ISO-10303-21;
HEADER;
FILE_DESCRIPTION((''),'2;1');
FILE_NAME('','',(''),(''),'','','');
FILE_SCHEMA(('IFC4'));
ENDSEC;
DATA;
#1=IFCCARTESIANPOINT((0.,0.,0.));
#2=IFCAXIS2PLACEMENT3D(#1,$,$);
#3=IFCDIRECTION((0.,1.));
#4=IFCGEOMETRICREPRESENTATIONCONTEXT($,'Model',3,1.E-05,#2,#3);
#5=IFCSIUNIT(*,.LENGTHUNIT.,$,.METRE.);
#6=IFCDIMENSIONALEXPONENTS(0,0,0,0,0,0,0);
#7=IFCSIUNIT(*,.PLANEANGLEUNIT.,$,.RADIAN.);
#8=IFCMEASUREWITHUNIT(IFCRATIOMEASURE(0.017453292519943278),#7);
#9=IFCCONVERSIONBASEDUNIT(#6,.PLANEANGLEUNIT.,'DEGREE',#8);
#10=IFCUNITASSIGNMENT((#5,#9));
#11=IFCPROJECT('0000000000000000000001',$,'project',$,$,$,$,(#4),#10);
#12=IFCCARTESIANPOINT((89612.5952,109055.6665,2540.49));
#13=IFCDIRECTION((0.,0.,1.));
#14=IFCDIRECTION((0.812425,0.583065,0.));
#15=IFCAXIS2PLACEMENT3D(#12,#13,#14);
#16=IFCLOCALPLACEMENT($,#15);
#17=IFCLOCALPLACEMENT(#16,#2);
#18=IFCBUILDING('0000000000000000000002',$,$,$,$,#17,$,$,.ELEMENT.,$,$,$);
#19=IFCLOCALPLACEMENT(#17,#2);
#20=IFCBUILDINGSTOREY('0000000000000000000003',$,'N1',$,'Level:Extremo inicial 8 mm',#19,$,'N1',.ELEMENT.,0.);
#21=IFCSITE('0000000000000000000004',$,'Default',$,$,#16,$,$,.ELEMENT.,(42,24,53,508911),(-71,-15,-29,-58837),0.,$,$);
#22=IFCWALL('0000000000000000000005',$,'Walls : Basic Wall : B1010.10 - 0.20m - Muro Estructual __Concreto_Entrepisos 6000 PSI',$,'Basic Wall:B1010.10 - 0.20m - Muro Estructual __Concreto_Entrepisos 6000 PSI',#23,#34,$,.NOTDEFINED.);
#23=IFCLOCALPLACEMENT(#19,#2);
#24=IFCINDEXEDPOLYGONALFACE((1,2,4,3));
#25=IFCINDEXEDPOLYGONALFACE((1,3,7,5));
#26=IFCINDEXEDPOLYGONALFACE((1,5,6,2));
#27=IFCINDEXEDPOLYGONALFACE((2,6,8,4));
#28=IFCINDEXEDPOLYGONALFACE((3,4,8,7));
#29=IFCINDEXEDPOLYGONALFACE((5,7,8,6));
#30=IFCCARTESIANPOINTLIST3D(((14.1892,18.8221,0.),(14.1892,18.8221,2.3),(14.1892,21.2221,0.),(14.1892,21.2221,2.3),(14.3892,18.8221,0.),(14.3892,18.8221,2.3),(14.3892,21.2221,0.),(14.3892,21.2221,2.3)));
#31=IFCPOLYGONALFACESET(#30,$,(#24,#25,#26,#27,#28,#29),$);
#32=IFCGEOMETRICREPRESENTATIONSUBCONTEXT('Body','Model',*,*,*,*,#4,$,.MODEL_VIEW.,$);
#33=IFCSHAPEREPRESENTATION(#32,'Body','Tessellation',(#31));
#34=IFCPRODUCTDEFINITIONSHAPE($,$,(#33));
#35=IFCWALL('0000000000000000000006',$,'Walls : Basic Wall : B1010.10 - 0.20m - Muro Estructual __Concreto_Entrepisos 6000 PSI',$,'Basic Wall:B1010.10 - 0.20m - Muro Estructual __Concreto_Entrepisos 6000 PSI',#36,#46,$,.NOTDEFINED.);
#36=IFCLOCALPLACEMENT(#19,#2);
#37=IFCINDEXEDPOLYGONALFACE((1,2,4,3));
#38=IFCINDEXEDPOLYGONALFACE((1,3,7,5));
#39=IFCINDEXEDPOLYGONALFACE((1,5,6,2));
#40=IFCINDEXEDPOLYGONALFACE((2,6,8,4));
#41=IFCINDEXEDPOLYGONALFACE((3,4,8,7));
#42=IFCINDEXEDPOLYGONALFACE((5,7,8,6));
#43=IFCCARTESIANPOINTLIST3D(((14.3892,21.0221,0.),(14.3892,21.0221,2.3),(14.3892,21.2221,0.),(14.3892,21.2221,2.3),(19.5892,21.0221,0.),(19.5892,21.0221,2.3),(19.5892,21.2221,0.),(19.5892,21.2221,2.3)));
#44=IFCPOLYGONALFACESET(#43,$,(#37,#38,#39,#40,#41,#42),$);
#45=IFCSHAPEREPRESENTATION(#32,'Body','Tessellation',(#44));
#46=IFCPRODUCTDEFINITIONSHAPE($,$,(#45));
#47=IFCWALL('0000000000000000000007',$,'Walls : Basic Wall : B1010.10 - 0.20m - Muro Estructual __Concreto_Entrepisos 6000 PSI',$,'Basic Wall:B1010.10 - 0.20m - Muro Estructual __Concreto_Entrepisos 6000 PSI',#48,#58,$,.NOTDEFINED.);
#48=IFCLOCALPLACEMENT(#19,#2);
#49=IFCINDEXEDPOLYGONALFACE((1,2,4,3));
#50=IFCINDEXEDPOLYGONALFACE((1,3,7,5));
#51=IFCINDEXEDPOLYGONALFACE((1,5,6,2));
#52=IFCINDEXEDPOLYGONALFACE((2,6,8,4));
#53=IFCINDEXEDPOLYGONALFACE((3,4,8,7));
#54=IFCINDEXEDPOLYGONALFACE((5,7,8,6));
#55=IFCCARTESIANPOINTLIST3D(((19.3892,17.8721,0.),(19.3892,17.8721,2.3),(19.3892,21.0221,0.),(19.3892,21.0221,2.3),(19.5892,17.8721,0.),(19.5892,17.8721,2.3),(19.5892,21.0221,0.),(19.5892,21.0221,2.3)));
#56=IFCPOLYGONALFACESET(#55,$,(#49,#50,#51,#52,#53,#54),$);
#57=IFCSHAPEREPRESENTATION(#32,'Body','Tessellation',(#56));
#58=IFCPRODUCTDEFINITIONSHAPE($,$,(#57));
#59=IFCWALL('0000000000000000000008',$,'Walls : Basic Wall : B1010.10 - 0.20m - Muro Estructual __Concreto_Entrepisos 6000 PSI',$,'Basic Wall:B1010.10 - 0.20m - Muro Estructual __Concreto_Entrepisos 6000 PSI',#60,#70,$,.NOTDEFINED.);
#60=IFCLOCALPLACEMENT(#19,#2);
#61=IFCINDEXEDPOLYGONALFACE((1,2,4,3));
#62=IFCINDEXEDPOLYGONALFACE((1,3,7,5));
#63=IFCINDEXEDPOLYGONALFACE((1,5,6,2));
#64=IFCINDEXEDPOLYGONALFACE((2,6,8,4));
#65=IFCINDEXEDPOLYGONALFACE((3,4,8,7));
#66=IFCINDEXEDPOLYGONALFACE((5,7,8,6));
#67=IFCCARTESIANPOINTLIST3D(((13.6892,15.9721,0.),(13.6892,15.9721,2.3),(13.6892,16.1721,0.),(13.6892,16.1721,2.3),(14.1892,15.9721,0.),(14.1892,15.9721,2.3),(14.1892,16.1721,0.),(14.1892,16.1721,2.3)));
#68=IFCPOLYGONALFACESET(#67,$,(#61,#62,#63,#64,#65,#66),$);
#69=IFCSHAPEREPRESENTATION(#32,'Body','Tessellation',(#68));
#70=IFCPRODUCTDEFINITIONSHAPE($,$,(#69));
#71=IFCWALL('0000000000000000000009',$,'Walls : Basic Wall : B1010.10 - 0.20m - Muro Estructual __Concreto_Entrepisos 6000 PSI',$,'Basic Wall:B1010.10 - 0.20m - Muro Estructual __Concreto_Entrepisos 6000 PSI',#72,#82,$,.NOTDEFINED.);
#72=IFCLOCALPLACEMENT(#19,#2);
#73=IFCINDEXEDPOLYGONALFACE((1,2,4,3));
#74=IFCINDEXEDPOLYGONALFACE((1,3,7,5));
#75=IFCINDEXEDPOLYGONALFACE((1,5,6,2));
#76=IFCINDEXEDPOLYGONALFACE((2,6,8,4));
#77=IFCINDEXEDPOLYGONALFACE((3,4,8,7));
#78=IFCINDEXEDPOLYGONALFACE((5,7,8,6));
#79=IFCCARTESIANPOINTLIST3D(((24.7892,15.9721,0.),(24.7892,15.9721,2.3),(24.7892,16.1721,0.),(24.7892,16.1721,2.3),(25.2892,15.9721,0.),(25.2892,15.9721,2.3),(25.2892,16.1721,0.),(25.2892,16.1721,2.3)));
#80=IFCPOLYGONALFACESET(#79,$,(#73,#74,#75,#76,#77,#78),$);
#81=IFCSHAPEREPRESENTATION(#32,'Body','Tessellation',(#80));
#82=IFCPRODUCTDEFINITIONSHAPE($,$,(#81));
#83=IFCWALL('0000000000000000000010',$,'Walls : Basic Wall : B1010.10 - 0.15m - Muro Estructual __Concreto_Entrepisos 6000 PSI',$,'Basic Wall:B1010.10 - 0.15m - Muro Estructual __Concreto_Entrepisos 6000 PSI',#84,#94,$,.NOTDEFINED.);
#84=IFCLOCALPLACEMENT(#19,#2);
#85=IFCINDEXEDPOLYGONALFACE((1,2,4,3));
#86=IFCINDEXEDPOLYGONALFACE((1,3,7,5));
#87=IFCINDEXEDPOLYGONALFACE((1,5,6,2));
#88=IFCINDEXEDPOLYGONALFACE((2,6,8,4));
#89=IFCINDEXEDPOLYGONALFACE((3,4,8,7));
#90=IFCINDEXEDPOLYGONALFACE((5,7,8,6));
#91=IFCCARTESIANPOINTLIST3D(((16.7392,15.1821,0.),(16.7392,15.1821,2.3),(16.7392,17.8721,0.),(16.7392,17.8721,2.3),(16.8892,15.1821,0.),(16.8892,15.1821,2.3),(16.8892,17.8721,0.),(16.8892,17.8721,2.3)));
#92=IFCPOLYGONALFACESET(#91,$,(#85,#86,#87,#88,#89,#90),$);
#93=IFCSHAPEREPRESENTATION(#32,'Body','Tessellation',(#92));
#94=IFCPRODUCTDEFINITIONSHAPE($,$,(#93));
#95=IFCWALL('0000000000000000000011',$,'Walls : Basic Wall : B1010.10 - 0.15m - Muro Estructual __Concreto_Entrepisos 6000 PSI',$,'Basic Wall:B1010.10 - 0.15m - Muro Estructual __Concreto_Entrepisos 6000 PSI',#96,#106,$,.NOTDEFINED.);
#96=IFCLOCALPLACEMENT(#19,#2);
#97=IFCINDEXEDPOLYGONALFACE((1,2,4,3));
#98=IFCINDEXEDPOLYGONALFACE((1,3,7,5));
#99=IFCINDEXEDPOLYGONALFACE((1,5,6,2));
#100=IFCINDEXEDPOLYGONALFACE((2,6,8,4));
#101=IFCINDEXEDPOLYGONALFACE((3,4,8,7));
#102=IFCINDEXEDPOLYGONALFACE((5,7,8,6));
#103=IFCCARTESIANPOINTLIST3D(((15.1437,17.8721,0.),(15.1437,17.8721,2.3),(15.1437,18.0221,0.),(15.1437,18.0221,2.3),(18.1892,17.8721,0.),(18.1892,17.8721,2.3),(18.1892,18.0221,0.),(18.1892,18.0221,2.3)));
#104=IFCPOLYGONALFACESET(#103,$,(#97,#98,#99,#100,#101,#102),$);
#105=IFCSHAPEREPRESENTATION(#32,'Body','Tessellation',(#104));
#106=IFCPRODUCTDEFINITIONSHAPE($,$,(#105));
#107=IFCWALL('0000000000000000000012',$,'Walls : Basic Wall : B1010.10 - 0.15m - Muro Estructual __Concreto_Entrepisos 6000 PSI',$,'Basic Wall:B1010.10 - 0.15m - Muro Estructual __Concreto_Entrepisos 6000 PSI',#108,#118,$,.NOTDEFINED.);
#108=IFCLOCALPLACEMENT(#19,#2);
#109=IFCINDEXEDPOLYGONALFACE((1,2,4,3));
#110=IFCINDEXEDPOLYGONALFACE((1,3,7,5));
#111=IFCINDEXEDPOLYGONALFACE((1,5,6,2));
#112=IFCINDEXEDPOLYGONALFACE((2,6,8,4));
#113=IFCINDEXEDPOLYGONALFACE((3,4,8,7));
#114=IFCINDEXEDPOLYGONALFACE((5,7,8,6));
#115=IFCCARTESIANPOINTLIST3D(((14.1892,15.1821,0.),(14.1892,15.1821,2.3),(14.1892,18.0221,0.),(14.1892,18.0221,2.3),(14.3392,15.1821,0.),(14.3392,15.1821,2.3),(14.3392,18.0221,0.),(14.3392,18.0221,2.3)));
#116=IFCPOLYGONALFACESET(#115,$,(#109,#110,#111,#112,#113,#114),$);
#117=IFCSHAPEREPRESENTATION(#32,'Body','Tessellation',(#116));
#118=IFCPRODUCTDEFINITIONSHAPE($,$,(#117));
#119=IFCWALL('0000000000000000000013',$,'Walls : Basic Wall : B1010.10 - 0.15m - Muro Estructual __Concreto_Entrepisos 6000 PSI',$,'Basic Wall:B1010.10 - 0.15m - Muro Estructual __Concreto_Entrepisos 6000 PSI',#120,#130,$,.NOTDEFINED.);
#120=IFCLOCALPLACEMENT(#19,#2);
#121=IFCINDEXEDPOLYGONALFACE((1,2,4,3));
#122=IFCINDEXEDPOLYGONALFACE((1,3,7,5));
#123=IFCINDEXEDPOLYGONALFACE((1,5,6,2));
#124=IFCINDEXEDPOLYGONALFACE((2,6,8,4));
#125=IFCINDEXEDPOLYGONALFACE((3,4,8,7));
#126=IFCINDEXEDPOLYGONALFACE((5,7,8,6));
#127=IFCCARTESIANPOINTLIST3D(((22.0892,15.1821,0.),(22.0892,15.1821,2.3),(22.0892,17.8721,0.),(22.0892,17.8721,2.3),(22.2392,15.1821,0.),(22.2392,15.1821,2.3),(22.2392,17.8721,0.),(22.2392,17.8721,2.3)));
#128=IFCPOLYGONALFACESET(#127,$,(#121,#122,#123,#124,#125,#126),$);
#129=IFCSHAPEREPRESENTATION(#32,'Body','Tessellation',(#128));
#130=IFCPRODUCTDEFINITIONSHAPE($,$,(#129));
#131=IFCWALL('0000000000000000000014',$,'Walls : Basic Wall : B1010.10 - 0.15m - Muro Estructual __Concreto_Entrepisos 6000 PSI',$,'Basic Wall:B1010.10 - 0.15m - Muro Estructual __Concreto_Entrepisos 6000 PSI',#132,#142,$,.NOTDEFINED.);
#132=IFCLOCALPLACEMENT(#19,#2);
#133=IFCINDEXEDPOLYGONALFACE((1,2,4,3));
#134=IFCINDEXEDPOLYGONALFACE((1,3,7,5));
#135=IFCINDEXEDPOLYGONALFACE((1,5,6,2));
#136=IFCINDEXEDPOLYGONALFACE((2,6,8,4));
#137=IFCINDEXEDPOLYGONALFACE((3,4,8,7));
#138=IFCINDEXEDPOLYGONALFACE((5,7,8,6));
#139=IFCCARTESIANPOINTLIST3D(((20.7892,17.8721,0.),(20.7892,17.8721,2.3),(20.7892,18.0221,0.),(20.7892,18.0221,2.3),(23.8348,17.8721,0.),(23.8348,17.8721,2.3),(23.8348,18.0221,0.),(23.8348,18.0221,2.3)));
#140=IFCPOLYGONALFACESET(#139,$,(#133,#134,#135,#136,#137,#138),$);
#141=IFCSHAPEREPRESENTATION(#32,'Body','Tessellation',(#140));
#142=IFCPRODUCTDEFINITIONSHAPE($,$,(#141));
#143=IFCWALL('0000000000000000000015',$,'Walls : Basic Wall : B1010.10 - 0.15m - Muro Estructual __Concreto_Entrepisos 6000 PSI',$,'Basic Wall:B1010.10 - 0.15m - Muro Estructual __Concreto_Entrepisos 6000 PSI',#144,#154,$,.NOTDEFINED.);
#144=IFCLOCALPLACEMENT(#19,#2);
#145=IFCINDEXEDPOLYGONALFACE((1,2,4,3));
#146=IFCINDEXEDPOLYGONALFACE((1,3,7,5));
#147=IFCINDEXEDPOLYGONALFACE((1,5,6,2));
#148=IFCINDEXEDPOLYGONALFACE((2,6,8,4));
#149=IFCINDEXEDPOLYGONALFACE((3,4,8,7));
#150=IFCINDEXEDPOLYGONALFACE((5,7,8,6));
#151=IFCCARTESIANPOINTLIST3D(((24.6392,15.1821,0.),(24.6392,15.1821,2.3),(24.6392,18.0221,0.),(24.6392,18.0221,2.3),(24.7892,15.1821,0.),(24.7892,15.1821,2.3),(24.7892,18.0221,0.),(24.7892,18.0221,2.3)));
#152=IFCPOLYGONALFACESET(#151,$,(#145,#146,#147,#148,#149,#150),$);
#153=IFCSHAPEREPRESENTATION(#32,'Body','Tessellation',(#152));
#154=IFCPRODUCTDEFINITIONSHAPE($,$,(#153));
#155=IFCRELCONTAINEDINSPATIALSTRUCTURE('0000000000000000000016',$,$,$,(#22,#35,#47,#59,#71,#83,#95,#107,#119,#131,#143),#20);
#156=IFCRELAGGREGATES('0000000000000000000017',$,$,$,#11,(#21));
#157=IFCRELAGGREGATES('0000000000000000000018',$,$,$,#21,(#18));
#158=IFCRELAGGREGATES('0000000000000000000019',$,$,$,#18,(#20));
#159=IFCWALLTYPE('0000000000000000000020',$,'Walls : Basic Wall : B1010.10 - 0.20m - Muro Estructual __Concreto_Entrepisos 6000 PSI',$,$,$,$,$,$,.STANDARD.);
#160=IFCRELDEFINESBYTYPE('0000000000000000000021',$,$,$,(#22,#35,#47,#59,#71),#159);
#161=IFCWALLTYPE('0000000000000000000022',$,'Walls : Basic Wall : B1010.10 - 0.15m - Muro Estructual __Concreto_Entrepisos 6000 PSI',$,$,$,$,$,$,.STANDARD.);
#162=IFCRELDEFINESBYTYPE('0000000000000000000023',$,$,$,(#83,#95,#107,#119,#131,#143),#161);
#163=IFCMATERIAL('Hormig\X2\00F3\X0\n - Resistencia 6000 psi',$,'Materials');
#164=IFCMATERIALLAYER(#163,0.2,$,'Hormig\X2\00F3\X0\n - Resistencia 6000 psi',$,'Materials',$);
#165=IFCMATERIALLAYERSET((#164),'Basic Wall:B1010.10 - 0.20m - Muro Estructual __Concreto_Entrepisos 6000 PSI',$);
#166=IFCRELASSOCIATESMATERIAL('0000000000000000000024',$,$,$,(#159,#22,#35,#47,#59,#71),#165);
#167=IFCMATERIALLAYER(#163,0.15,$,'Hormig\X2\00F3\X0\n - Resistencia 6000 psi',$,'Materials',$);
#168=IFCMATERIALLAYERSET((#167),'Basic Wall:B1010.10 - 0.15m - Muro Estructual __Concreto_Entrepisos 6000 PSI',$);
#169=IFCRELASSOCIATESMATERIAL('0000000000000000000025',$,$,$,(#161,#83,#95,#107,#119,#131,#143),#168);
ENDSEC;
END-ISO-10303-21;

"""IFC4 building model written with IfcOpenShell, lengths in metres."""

from ifc_helpers import new_model, entity, si_unit, converted_unit, direction, frame, frame_2d, origin, place, context, subcontext, project, spatial, rectangle, extrude, material, layer, layer_set, layer_usage, type_object, element, save


model = new_model("IFC4")

# Units and contexts
model_context = context("Model", 3, precision=1e-05, world=origin(), true_north=direction((0.0, 1.0)))
body_context = subcontext(model_context, "Body", "Model", "MODEL_VIEW")
ifc_project = project(units=[si_unit("LENGTHUNIT", "METRE"), converted_unit("PLANEANGLEUNIT", "DEGREE", entity("IfcRatioMeasure", 0.017453292519943278), si_unit("PLANEANGLEUNIT", "RADIAN"), dimensions=[0, 0, 0, 0, 0, 0, 0])], contexts=[model_context])

# Site, building, storey
site_placement = place(None, frame((89612.5952, 109055.6665, 2540.49), z_axis=(0.0, 0.0, 1.0), x_axis=(0.812425, 0.583065, 0.0)))
site = spatial("IfcSite", under=ifc_project, at=site_placement, Name="Default", CompositionType="ELEMENT", RefLatitude=(42, 24, 53, 508911), RefLongitude=(-71, -15, -29, -58837), RefElevation=0.0)
building_placement = place(site_placement, origin())
building = spatial("IfcBuilding", under=site, at=building_placement, CompositionType="ELEMENT")
storey_placement = place(building_placement, origin())
storey = spatial("IfcBuildingStorey", under=building, at=storey_placement, Name="N1", ObjectType="Level:Extremo inicial 8 mm", LongName="N1", CompositionType="ELEMENT", Elevation=0.0)

# Walls
ifc_material_1 = material(Name="Hormigón - Resistencia 6000 psi", Category="Materials")
ifc_layer_1 = layer(ifc_material_1, 0.2, Name="Hormigón - Resistencia 6000 psi", Category="Materials")
ifc_layer_set_1 = layer_set([ifc_layer_1], Name="Basic Wall:B1010.10 - 0.20m - Muro Estructual __Concreto_Entrepisos 6000 PSI")
ifc_layer_usage_1 = layer_usage(ifc_layer_set_1, "AXIS2", "NEGATIVE", 0.1)
wall_type_1 = type_object("IfcWallType", Name="Walls : Basic Wall : B1010.10 - 0.20m - Muro Estructual __Concreto_Entrepisos 6000 PSI", PredefinedType="STANDARD", material=ifc_layer_set_1)
wall_1_placement = place(storey_placement, frame((14.2892, 18.8221, 0.0), z_axis=(0.0, 0.0, 1.0), x_axis=(0.0, 1.0, 0.0)))
element("IfcWall", 1, at=wall_1_placement, inside=storey, type_object=wall_type_1, material=ifc_layer_usage_1, Name="Walls : Basic Wall : B1010.10 - 0.20m - Muro Estructual __Concreto_Entrepisos 6000 PSI", ObjectType="Basic Wall:B1010.10 - 0.20m - Muro Estructual __Concreto_Entrepisos 6000 PSI", PredefinedType="NOTDEFINED", context=body_context, shape_type="SweptSolid", body=[
    extrude(rectangle(XDim=2.4, YDim=0.2, at=frame_2d((1.2, 0.0), x_axis=(-1.0, 0.0))), origin(), (0.0, 0.0, 1.0), 2.3),
])
ifc_layer_usage_2 = layer_usage(ifc_layer_set_1, "AXIS2", "NEGATIVE", 0.1)
wall_2_placement = place(storey_placement, frame((14.3892, 21.1221, 0.0)))
element("IfcWall", 2, at=wall_2_placement, inside=storey, type_object=wall_type_1, material=ifc_layer_usage_2, Name="Walls : Basic Wall : B1010.10 - 0.20m - Muro Estructual __Concreto_Entrepisos 6000 PSI", ObjectType="Basic Wall:B1010.10 - 0.20m - Muro Estructual __Concreto_Entrepisos 6000 PSI", PredefinedType="NOTDEFINED", context=body_context, shape_type="SweptSolid", body=[
    extrude(rectangle(XDim=5.2, YDim=0.2, at=frame_2d((2.6, 0.0), x_axis=(-1.0, 0.0))), origin(), (0.0, 0.0, 1.0), 2.3),
])
ifc_layer_usage_3 = layer_usage(ifc_layer_set_1, "AXIS2", "NEGATIVE", 0.1)
wall_3_placement = place(storey_placement, frame((19.4892, 21.0221, 0.0), z_axis=(0.0, 0.0, 1.0), x_axis=(0.0, -1.0, 0.0)))
element("IfcWall", 3, at=wall_3_placement, inside=storey, type_object=wall_type_1, material=ifc_layer_usage_3, Name="Walls : Basic Wall : B1010.10 - 0.20m - Muro Estructual __Concreto_Entrepisos 6000 PSI", ObjectType="Basic Wall:B1010.10 - 0.20m - Muro Estructual __Concreto_Entrepisos 6000 PSI", PredefinedType="NOTDEFINED", context=body_context, shape_type="SweptSolid", body=[
    extrude(rectangle(XDim=3.15, YDim=0.2, at=frame_2d((1.575, 0.0), x_axis=(-1.0, 0.0))), origin(), (0.0, 0.0, 1.0), 2.3),
])
ifc_layer_usage_4 = layer_usage(ifc_layer_set_1, "AXIS2", "NEGATIVE", 0.1)
wall_4_placement = place(storey_placement, frame((13.6892, 16.0721, 0.0)))
element("IfcWall", 4, at=wall_4_placement, inside=storey, type_object=wall_type_1, material=ifc_layer_usage_4, Name="Walls : Basic Wall : B1010.10 - 0.20m - Muro Estructual __Concreto_Entrepisos 6000 PSI", ObjectType="Basic Wall:B1010.10 - 0.20m - Muro Estructual __Concreto_Entrepisos 6000 PSI", PredefinedType="NOTDEFINED", context=body_context, shape_type="SweptSolid", body=[
    extrude(rectangle(XDim=0.5, YDim=0.2, at=frame_2d((0.25, 0.0), x_axis=(-1.0, 0.0))), origin(), (0.0, 0.0, 1.0), 2.3),
])
ifc_layer_usage_5 = layer_usage(ifc_layer_set_1, "AXIS2", "POSITIVE", -0.1)
wall_5_placement = place(storey_placement, frame((25.2892, 16.0721, 0.0), z_axis=(0.0, 0.0, 1.0), x_axis=(-1.0, 0.0, 0.0)))
element("IfcWall", 5, at=wall_5_placement, inside=storey, type_object=wall_type_1, material=ifc_layer_usage_5, Name="Walls : Basic Wall : B1010.10 - 0.20m - Muro Estructual __Concreto_Entrepisos 6000 PSI", ObjectType="Basic Wall:B1010.10 - 0.20m - Muro Estructual __Concreto_Entrepisos 6000 PSI", PredefinedType="NOTDEFINED", context=body_context, shape_type="SweptSolid", body=[
    extrude(rectangle(XDim=0.5, YDim=0.2, at=frame_2d((0.25, 0.0), x_axis=(-1.0, 0.0))), origin(), (0.0, 0.0, 1.0), 2.3),
])
ifc_layer_2 = layer(ifc_material_1, 0.15, Name="Hormigón - Resistencia 6000 psi", Category="Materials")
ifc_layer_set_2 = layer_set([ifc_layer_2], Name="Basic Wall:B1010.10 - 0.15m - Muro Estructual __Concreto_Entrepisos 6000 PSI")
ifc_layer_usage_6 = layer_usage(ifc_layer_set_2, "AXIS2", "NEGATIVE", 0.075)
wall_type_2 = type_object("IfcWallType", Name="Walls : Basic Wall : B1010.10 - 0.15m - Muro Estructual __Concreto_Entrepisos 6000 PSI", PredefinedType="STANDARD", material=ifc_layer_set_2)
wall_6_placement = place(storey_placement, frame((16.8142, 15.1821, 0.0), z_axis=(0.0, 0.0, 1.0), x_axis=(0.0, 1.0, 0.0)))
element("IfcWall", 6, at=wall_6_placement, inside=storey, type_object=wall_type_2, material=ifc_layer_usage_6, Name="Walls : Basic Wall : B1010.10 - 0.15m - Muro Estructual __Concreto_Entrepisos 6000 PSI", ObjectType="Basic Wall:B1010.10 - 0.15m - Muro Estructual __Concreto_Entrepisos 6000 PSI", PredefinedType="NOTDEFINED", context=body_context, shape_type="SweptSolid", body=[
    extrude(rectangle(XDim=2.69, YDim=0.15, at=frame_2d((1.345, 0.0), x_axis=(-1.0, 0.0))), origin(), (0.0, 0.0, 1.0), 2.3),
])
ifc_layer_usage_7 = layer_usage(ifc_layer_set_2, "AXIS2", "NEGATIVE", 0.075)
wall_7_placement = place(storey_placement, frame((18.1892, 17.9471, 0.0), z_axis=(0.0, 0.0, 1.0), x_axis=(-1.0, 0.0, 0.0)))
element("IfcWall", 7, at=wall_7_placement, inside=storey, type_object=wall_type_2, material=ifc_layer_usage_7, Name="Walls : Basic Wall : B1010.10 - 0.15m - Muro Estructual __Concreto_Entrepisos 6000 PSI", ObjectType="Basic Wall:B1010.10 - 0.15m - Muro Estructual __Concreto_Entrepisos 6000 PSI", PredefinedType="NOTDEFINED", context=body_context, shape_type="SweptSolid", body=[
    extrude(rectangle(XDim=3.0455, YDim=0.15, at=frame_2d((1.5228, 0.0), x_axis=(-1.0, 0.0))), origin(), (0.0, 0.0, 1.0), 2.3),
])
ifc_layer_usage_8 = layer_usage(ifc_layer_set_2, "AXIS2", "NEGATIVE", 0.075)
wall_8_placement = place(storey_placement, frame((14.2642, 15.1821, 0.0), z_axis=(0.0, 0.0, 1.0), x_axis=(0.0, 1.0, 0.0)))
element("IfcWall", 8, at=wall_8_placement, inside=storey, type_object=wall_type_2, material=ifc_layer_usage_8, Name="Walls : Basic Wall : B1010.10 - 0.15m - Muro Estructual __Concreto_Entrepisos 6000 PSI", ObjectType="Basic Wall:B1010.10 - 0.15m - Muro Estructual __Concreto_Entrepisos 6000 PSI", PredefinedType="NOTDEFINED", context=body_context, shape_type="SweptSolid", body=[
    extrude(rectangle(XDim=2.84, YDim=0.15, at=frame_2d((1.42, 0.0), x_axis=(-1.0, 0.0))), origin(), (0.0, 0.0, 1.0), 2.3),
])
ifc_layer_usage_9 = layer_usage(ifc_layer_set_2, "AXIS2", "POSITIVE", -0.075)
wall_9_placement = place(storey_placement, frame((22.1642, 15.1821, 0.0), z_axis=(0.0, 0.0, 1.0), x_axis=(0.0, 1.0, 0.0)))
element("IfcWall", 9, at=wall_9_placement, inside=storey, type_object=wall_type_2, material=ifc_layer_usage_9, Name="Walls : Basic Wall : B1010.10 - 0.15m - Muro Estructual __Concreto_Entrepisos 6000 PSI", ObjectType="Basic Wall:B1010.10 - 0.15m - Muro Estructual __Concreto_Entrepisos 6000 PSI", PredefinedType="NOTDEFINED", context=body_context, shape_type="SweptSolid", body=[
    extrude(rectangle(XDim=2.69, YDim=0.15, at=frame_2d((1.345, 0.0), x_axis=(-1.0, 0.0))), origin(), (0.0, 0.0, 1.0), 2.3),
])
ifc_layer_usage_10 = layer_usage(ifc_layer_set_2, "AXIS2", "POSITIVE", -0.075)
wall_10_placement = place(storey_placement, frame((20.7892, 17.9471, 0.0)))
element("IfcWall", 10, at=wall_10_placement, inside=storey, type_object=wall_type_2, material=ifc_layer_usage_10, Name="Walls : Basic Wall : B1010.10 - 0.15m - Muro Estructual __Concreto_Entrepisos 6000 PSI", ObjectType="Basic Wall:B1010.10 - 0.15m - Muro Estructual __Concreto_Entrepisos 6000 PSI", PredefinedType="NOTDEFINED", context=body_context, shape_type="SweptSolid", body=[
    extrude(rectangle(XDim=3.0455, YDim=0.15, at=frame_2d((1.5228, 0.0), x_axis=(-1.0, 0.0))), origin(), (0.0, 0.0, 1.0), 2.3),
])
ifc_layer_usage_11 = layer_usage(ifc_layer_set_2, "AXIS2", "POSITIVE", -0.075)
wall_11_placement = place(storey_placement, frame((24.7142, 15.1821, 0.0), z_axis=(0.0, 0.0, 1.0), x_axis=(0.0, 1.0, 0.0)))
element("IfcWall", 11, at=wall_11_placement, inside=storey, type_object=wall_type_2, material=ifc_layer_usage_11, Name="Walls : Basic Wall : B1010.10 - 0.15m - Muro Estructual __Concreto_Entrepisos 6000 PSI", ObjectType="Basic Wall:B1010.10 - 0.15m - Muro Estructual __Concreto_Entrepisos 6000 PSI", PredefinedType="NOTDEFINED", context=body_context, shape_type="SweptSolid", body=[
    extrude(rectangle(XDim=2.84, YDim=0.15, at=frame_2d((1.42, 0.0), x_axis=(-1.0, 0.0))), origin(), (0.0, 0.0, 1.0), 2.3),
])

save(model, "model.ifc")
